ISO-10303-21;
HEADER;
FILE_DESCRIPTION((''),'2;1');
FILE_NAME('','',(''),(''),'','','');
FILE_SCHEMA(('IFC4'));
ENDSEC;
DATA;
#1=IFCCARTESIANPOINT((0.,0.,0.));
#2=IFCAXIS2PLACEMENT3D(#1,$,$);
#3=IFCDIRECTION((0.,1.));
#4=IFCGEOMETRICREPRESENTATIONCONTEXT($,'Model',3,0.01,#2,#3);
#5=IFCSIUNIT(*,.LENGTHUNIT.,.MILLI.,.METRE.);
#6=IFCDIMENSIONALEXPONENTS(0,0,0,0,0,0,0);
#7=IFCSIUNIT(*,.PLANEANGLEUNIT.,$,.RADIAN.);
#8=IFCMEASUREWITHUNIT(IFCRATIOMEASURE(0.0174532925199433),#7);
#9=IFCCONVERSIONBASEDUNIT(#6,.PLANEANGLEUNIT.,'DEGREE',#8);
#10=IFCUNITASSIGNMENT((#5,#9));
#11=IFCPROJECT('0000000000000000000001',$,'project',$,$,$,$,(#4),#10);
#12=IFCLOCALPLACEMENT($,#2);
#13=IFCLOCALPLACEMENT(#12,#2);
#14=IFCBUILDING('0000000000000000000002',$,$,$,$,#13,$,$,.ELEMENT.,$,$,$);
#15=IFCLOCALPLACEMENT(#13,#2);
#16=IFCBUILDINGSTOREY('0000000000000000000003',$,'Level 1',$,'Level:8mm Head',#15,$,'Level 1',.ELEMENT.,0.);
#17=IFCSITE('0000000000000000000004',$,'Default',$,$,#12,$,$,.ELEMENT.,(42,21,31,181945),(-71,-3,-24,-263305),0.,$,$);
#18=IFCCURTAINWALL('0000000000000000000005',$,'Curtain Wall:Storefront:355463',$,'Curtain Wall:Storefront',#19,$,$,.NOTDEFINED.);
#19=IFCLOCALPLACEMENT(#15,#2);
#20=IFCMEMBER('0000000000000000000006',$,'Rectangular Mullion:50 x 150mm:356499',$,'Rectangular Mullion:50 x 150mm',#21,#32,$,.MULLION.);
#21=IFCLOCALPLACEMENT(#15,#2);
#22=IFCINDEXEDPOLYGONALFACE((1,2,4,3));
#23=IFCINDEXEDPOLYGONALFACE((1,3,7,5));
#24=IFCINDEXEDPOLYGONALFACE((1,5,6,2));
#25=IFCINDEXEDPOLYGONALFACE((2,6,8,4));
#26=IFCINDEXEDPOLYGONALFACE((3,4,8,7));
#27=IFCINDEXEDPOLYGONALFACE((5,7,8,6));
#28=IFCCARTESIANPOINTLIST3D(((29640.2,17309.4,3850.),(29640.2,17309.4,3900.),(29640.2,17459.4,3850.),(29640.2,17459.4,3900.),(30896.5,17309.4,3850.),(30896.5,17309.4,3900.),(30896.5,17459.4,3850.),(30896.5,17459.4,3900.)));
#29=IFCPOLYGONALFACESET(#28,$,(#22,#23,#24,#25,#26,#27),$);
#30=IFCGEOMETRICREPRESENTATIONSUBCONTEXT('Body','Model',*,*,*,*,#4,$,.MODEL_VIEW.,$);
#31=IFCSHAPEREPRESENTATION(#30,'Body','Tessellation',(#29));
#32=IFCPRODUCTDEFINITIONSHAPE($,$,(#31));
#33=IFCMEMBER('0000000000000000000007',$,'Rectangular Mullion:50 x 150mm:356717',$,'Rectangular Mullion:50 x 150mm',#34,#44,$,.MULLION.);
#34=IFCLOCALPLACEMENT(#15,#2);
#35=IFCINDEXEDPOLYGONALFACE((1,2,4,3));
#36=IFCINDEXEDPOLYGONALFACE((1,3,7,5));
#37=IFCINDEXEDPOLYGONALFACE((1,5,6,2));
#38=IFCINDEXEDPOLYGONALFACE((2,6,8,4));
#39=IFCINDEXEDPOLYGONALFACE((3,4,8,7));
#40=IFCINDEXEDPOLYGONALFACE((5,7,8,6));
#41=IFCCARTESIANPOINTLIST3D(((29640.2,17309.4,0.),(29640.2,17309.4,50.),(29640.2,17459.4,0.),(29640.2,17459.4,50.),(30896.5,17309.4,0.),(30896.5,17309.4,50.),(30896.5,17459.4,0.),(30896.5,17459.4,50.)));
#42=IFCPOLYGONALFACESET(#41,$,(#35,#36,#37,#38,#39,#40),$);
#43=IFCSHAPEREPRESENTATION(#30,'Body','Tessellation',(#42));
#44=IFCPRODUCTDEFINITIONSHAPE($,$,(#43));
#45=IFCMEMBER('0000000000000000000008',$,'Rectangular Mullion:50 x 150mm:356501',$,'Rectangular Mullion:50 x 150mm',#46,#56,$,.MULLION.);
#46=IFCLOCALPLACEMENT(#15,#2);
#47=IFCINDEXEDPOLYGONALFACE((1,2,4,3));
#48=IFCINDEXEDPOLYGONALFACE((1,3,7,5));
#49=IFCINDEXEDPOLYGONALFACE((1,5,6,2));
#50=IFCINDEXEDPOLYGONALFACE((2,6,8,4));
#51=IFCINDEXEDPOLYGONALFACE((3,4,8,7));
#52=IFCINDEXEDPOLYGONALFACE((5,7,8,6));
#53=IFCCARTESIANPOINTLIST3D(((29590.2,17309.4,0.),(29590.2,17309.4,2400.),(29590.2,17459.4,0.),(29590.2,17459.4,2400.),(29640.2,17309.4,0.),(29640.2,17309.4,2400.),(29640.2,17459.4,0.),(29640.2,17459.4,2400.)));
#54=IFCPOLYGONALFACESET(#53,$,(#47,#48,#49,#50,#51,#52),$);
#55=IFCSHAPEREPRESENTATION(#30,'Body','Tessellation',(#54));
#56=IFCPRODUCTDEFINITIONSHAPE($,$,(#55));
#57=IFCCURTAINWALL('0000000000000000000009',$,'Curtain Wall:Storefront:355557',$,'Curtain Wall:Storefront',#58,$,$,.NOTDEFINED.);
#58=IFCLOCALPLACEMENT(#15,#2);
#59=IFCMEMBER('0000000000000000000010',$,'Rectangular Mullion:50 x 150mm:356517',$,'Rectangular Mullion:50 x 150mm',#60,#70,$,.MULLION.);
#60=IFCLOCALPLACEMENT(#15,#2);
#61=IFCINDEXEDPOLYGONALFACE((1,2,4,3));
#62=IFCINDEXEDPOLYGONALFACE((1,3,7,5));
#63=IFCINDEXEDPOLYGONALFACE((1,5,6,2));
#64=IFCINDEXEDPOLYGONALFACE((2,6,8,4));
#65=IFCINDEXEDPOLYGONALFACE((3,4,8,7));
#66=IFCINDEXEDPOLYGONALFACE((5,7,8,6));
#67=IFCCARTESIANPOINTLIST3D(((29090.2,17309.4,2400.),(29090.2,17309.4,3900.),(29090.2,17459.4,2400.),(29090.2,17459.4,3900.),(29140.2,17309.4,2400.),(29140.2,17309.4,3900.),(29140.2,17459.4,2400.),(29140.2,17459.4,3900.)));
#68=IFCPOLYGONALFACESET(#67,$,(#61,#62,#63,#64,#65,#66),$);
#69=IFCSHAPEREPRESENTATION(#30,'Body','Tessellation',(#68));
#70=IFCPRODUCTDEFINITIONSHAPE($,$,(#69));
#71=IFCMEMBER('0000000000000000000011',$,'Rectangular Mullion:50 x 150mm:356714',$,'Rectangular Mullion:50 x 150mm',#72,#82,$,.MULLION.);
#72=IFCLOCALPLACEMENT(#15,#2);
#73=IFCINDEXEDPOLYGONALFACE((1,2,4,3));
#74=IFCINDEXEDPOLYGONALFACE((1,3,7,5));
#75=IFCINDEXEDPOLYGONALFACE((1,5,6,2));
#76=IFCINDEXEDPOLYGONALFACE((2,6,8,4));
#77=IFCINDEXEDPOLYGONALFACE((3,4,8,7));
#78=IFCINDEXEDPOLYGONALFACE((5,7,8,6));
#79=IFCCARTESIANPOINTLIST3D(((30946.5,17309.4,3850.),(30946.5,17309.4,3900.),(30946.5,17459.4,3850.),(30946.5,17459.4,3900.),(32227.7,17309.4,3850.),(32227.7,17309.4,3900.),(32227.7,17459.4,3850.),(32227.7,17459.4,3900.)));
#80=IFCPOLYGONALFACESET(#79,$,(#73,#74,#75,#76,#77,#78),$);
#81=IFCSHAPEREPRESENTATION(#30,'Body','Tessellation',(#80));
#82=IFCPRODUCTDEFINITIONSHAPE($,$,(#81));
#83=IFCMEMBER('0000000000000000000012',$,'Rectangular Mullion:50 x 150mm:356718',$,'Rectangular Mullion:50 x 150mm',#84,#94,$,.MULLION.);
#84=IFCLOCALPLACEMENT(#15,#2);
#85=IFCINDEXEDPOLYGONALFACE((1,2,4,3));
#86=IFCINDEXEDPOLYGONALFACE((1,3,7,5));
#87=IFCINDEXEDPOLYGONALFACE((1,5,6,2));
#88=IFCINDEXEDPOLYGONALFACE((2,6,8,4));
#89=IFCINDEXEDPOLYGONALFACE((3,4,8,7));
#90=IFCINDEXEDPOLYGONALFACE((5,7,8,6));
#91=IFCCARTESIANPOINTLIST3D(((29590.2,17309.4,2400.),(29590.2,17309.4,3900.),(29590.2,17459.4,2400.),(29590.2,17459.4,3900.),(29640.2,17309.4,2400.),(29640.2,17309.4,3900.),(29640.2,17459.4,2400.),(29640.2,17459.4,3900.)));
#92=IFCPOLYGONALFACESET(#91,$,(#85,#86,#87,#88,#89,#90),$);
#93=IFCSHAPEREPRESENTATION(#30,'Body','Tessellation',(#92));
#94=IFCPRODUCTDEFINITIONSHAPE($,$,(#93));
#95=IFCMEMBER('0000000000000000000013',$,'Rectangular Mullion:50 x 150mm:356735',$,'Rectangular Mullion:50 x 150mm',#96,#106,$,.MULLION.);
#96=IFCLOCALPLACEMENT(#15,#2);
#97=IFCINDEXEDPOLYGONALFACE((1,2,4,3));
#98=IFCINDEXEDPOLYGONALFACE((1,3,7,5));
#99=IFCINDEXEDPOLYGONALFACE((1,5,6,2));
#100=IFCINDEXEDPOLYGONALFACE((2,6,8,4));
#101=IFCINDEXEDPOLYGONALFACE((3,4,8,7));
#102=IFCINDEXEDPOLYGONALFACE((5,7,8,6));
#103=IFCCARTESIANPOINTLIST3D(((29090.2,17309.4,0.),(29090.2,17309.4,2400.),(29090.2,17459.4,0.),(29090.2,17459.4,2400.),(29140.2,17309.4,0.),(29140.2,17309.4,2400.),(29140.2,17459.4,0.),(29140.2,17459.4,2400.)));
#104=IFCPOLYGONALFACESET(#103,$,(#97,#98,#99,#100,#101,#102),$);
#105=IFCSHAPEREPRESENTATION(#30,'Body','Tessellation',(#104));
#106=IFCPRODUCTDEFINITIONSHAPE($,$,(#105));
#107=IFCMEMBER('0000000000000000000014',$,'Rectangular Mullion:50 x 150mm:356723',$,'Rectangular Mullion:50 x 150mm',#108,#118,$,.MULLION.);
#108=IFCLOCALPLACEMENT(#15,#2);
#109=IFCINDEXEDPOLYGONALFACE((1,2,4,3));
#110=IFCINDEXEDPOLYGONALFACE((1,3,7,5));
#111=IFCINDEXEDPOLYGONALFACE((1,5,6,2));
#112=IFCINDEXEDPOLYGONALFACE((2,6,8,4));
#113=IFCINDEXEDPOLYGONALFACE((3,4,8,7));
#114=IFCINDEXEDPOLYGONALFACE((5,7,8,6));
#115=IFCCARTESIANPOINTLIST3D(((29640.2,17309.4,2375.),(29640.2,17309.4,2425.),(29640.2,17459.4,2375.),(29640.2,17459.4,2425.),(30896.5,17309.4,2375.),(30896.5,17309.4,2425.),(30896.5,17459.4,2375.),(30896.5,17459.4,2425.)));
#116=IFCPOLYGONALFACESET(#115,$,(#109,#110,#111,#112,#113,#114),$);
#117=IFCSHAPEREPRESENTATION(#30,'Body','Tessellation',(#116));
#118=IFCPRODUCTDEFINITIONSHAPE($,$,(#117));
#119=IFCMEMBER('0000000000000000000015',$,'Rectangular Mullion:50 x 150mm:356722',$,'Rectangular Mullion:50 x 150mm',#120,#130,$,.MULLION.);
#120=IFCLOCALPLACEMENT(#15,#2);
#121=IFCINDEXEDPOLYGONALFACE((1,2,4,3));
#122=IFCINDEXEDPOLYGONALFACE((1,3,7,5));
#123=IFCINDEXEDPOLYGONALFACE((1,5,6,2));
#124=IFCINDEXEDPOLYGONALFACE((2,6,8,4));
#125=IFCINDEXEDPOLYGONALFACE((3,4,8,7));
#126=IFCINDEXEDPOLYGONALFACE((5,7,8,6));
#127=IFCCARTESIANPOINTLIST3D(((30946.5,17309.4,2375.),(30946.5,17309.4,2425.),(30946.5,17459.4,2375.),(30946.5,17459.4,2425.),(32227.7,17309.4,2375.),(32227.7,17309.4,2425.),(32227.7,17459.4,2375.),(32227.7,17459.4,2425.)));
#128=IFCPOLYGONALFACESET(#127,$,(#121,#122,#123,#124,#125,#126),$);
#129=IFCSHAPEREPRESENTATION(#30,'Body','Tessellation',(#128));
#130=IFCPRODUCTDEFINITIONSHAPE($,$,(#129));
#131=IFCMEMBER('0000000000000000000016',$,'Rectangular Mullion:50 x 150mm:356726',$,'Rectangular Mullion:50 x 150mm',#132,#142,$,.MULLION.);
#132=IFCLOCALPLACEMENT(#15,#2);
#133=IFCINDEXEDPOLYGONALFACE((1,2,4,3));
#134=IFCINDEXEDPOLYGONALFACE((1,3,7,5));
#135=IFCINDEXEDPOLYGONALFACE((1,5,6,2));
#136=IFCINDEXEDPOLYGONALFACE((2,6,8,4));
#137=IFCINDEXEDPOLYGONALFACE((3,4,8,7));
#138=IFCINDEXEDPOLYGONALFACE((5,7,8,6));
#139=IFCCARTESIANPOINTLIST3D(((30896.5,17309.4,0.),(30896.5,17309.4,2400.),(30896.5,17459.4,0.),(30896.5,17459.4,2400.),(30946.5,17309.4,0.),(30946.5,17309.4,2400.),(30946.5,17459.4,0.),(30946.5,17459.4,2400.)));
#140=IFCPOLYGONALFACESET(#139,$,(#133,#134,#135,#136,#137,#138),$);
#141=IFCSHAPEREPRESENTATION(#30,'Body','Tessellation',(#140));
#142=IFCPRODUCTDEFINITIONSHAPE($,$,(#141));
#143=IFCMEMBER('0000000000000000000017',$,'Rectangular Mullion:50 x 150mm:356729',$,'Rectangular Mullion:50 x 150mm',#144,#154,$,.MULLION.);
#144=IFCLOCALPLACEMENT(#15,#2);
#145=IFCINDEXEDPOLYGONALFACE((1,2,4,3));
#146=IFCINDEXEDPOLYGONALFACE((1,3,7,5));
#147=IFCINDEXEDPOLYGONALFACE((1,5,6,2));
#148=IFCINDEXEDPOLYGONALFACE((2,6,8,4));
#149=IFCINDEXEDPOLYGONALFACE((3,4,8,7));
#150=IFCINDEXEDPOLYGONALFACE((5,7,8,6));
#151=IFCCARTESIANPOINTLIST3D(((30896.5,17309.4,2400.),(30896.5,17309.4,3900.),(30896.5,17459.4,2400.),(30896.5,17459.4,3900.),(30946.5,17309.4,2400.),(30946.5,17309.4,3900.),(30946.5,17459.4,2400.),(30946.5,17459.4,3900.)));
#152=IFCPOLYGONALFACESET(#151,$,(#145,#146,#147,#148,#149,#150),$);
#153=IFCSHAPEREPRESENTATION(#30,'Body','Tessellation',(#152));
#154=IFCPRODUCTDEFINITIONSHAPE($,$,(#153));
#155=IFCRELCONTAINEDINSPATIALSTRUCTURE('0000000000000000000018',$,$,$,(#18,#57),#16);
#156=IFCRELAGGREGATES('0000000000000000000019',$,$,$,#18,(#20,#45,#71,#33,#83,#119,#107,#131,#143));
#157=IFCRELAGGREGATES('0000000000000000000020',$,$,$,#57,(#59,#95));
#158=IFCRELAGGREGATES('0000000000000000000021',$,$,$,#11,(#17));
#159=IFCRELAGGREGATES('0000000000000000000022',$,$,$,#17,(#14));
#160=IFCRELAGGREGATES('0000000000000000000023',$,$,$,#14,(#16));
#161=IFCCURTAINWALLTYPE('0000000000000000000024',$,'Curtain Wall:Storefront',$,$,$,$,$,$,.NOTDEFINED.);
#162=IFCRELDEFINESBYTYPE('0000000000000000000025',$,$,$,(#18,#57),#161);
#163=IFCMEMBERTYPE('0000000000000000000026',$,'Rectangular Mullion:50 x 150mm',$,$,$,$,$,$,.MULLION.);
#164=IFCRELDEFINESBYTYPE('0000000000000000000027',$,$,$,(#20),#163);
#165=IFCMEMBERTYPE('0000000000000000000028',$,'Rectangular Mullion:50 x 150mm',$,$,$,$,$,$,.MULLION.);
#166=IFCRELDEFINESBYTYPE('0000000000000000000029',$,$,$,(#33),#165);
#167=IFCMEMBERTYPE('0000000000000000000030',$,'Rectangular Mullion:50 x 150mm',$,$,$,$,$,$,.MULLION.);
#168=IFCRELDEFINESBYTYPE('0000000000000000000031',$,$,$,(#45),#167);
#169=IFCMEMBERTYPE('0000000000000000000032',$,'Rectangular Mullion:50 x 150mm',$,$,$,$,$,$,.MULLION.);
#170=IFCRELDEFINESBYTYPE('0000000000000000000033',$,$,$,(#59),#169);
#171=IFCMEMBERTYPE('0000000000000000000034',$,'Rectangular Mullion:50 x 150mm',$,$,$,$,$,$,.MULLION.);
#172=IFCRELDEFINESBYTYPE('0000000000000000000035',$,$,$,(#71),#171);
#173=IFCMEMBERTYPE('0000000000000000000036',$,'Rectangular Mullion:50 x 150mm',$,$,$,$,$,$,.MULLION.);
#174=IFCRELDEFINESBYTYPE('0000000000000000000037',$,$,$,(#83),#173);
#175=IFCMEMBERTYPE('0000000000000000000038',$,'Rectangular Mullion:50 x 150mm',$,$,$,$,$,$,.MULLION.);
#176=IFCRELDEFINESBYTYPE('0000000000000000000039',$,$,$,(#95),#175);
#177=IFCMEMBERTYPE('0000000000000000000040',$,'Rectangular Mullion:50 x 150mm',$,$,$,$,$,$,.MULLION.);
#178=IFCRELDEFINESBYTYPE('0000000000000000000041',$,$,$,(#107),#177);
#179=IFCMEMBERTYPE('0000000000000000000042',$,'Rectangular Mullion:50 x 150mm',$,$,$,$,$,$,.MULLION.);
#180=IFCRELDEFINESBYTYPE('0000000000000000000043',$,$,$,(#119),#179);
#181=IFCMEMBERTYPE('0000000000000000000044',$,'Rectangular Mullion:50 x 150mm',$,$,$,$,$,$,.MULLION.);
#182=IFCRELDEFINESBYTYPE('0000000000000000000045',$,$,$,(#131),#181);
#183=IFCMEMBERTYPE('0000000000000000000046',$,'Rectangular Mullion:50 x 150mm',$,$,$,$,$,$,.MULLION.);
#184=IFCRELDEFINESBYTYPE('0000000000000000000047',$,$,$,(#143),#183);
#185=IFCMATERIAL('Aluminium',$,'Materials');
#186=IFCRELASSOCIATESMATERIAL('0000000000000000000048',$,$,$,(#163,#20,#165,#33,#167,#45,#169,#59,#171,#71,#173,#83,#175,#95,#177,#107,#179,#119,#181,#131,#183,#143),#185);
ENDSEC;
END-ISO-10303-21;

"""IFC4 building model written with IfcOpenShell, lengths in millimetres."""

from ifc_helpers import new_model, entity, si_unit, converted_unit, direction, frame, origin, place, context, subcontext, project, spatial, indexed_curve, outline, extrude, source, transform, mapped, material, type_object, type_shapes, element, aggregate, save


model = new_model("IFC4")

# Units and contexts
model_context = context("Model", 3, precision=0.01, world=origin(), true_north=direction((0.0, 1.0)))
body_context = subcontext(model_context, "Body", "Model", "MODEL_VIEW")
ifc_project = project(units=[si_unit("LENGTHUNIT", "METRE", prefix="MILLI"), converted_unit("PLANEANGLEUNIT", "DEGREE", entity("IfcRatioMeasure", 0.0174532925199433), si_unit("PLANEANGLEUNIT", "RADIAN"), dimensions=[0, 0, 0, 0, 0, 0, 0])], contexts=[model_context])

# Site, building, storey
site_placement = place(None, origin())
site = spatial("IfcSite", under=ifc_project, at=site_placement, Name="Default", CompositionType="ELEMENT", RefLatitude=(42, 21, 31, 181945), RefLongitude=(-71, -3, -24, -263305), RefElevation=0.0)
building_placement = place(site_placement, origin())
building = spatial("IfcBuilding", under=site, at=building_placement, CompositionType="ELEMENT")
storey_placement = place(building_placement, origin())
storey = spatial("IfcBuildingStorey", under=building, at=storey_placement, Name="Level 1", ObjectType="Level:8mm Head", LongName="Level 1", CompositionType="ELEMENT", Elevation=0.0)

# Curtain wall, members
curtain_wall_type_1 = type_object("IfcCurtainWallType", Name="Curtain Wall:Storefront", PredefinedType="NOTDEFINED")
curtain_wall_1_placement = place(storey_placement, origin())
curtain_wall_1 = element("IfcCurtainWall", 1, at=curtain_wall_1_placement, inside=storey, type_object=curtain_wall_type_1, Name="Curtain Wall:Storefront:355463", ObjectType="Curtain Wall:Storefront", PredefinedType="NOTDEFINED")
ifc_material_1 = material(Name="Aluminium", Category="Materials")
member_type_1 = type_object("IfcMemberType", Name="Rectangular Mullion:50 x 150mm", PredefinedType="MULLION", material=ifc_material_1)
shared_shape_1 = source(origin(), body_context, "Body", "SweptSolid", [
    extrude(outline(indexed_curve([(-75.0, -25.0), (75.0, -25.0), (75.0, 25.0), (-75.0, 25.0), (-75.0, -25.0)], self_intersect=False)), frame((-25.0, 0.0, -1256.3), z_axis=(0.0, 0.0, 1.0), x_axis=(0.0, -1.0, 0.0)), (0.0, 0.0, 1.0), 1256.3),
])
type_shapes(member_type_1, [shared_shape_1])
member_1_placement = place(storey_placement, frame((29640.2, 17384.4, 3900.0), z_axis=(-1.0, 0.0, 0.0), x_axis=(0.0, 0.0, 1.0)))
member_1 = element("IfcMember", 2, at=member_1_placement, type_object=member_type_1, material=ifc_material_1, Name="Rectangular Mullion:50 x 150mm:356499", ObjectType="Rectangular Mullion:50 x 150mm", PredefinedType="MULLION", context=body_context, shape_type="MappedRepresentation", body=[
    mapped(shared_shape_1, transform((0.0, 0.0, 0.0), scale=1.0)),
])
member_type_2 = type_object("IfcMemberType", Name="Rectangular Mullion:50 x 150mm", PredefinedType="MULLION", material=ifc_material_1)
shared_shape_2 = source(origin(), body_context, "Body", "SweptSolid", [
    extrude(outline(indexed_curve([(-75.0, -25.0), (75.0, -25.0), (75.0, 25.0), (-75.0, 25.0), (-75.0, -25.0)], self_intersect=False)), frame((-25.0, 0.0, -1256.3), z_axis=(0.0, 0.0, 1.0), x_axis=(0.0, -1.0, 0.0)), (0.0, 0.0, 1.0), 1256.3),
])
type_shapes(member_type_2, [shared_shape_2])
member_2_placement = place(storey_placement, frame((30896.5, 17384.4, 0.0), z_axis=(1.0, 0.0, 0.0), x_axis=(0.0, 0.0, -1.0)))
member_2 = element("IfcMember", 3, at=member_2_placement, type_object=member_type_2, material=ifc_material_1, Name="Rectangular Mullion:50 x 150mm:356717", ObjectType="Rectangular Mullion:50 x 150mm", PredefinedType="MULLION", context=body_context, shape_type="MappedRepresentation", body=[
    mapped(shared_shape_2, transform((0.0, 0.0, 0.0), scale=1.0)),
])
member_type_3 = type_object("IfcMemberType", Name="Rectangular Mullion:50 x 150mm", PredefinedType="MULLION", material=ifc_material_1)
shared_shape_3 = source(origin(), body_context, "Body", "SweptSolid", [
    extrude(outline(indexed_curve([(-75.0, -25.0), (75.0, -25.0), (75.0, 25.0), (-75.0, 25.0), (-75.0, -25.0)], self_intersect=False)), frame((-25.0, 0.0, -2400.0), z_axis=(0.0, 0.0, 1.0), x_axis=(0.0, -1.0, 0.0)), (0.0, 0.0, 1.0), 2400.0),
])
type_shapes(member_type_3, [shared_shape_3])
member_3_placement = place(storey_placement, frame((29590.2, 17384.4, 0.0), z_axis=(0.0, 0.0, -1.0), x_axis=(-1.0, 0.0, 0.0)))
member_3 = element("IfcMember", 4, at=member_3_placement, type_object=member_type_3, material=ifc_material_1, Name="Rectangular Mullion:50 x 150mm:356501", ObjectType="Rectangular Mullion:50 x 150mm", PredefinedType="MULLION", context=body_context, shape_type="MappedRepresentation", body=[
    mapped(shared_shape_3, transform((0.0, 0.0, 0.0), scale=1.0)),
])

# Curtain wall, member
curtain_wall_2_placement = place(storey_placement, origin())
curtain_wall_2 = element("IfcCurtainWall", 5, at=curtain_wall_2_placement, inside=storey, type_object=curtain_wall_type_1, Name="Curtain Wall:Storefront:355557", ObjectType="Curtain Wall:Storefront", PredefinedType="NOTDEFINED")
member_type_4 = type_object("IfcMemberType", Name="Rectangular Mullion:50 x 150mm", PredefinedType="MULLION", material=ifc_material_1)
shared_shape_4 = source(origin(), body_context, "Body", "SweptSolid", [
    extrude(outline(indexed_curve([(-75.0, -25.0), (75.0, -25.0), (75.0, 25.0), (-75.0, 25.0), (-75.0, -25.0)], self_intersect=False)), frame((-25.0, 0.0, -1500.0), z_axis=(0.0, 0.0, 1.0), x_axis=(0.0, -1.0, 0.0)), (0.0, 0.0, 1.0), 1500.0),
])
type_shapes(member_type_4, [shared_shape_4])
member_4_placement = place(storey_placement, frame((29140.2, 17384.4, 3900.0)))
member_4 = element("IfcMember", 6, at=member_4_placement, type_object=member_type_4, material=ifc_material_1, Name="Rectangular Mullion:50 x 150mm:356517", ObjectType="Rectangular Mullion:50 x 150mm", PredefinedType="MULLION", context=body_context, shape_type="MappedRepresentation", body=[
    mapped(shared_shape_4, transform((0.0, 0.0, 0.0), scale=1.0)),
])

# Members
member_type_5 = type_object("IfcMemberType", Name="Rectangular Mullion:50 x 150mm", PredefinedType="MULLION", material=ifc_material_1)
shared_shape_5 = source(origin(), body_context, "Body", "SweptSolid", [
    extrude(outline(indexed_curve([(-75.0, -25.0), (75.0, -25.0), (75.0, 25.0), (-75.0, 25.0), (-75.0, -25.0)], self_intersect=False)), frame((-25.0, 0.0, -1281.2), z_axis=(0.0, 0.0, 1.0), x_axis=(0.0, -1.0, 0.0)), (0.0, 0.0, 1.0), 1281.2),
])
type_shapes(member_type_5, [shared_shape_5])
member_5_placement = place(storey_placement, frame((30946.5, 17384.4, 3900.0), z_axis=(-1.0, 0.0, 0.0), x_axis=(0.0, 0.0, 1.0)))
member_5 = element("IfcMember", 7, at=member_5_placement, type_object=member_type_5, material=ifc_material_1, Name="Rectangular Mullion:50 x 150mm:356714", ObjectType="Rectangular Mullion:50 x 150mm", PredefinedType="MULLION", context=body_context, shape_type="MappedRepresentation", body=[
    mapped(shared_shape_5, transform((0.0, 0.0, 0.0), scale=1.0)),
])
member_type_6 = type_object("IfcMemberType", Name="Rectangular Mullion:50 x 150mm", PredefinedType="MULLION", material=ifc_material_1)
shared_shape_6 = source(origin(), body_context, "Body", "SweptSolid", [
    extrude(outline(indexed_curve([(-75.0, -25.0), (75.0, -25.0), (75.0, 25.0), (-75.0, 25.0), (-75.0, -25.0)], self_intersect=False)), frame((-25.0, 0.0, -1500.0), z_axis=(0.0, 0.0, 1.0), x_axis=(0.0, -1.0, 0.0)), (0.0, 0.0, 1.0), 1500.0),
])
type_shapes(member_type_6, [shared_shape_6])
member_6_placement = place(storey_placement, frame((29590.2, 17384.4, 2400.0), z_axis=(0.0, 0.0, -1.0), x_axis=(-1.0, 0.0, 0.0)))
member_6 = element("IfcMember", 8, at=member_6_placement, type_object=member_type_6, material=ifc_material_1, Name="Rectangular Mullion:50 x 150mm:356718", ObjectType="Rectangular Mullion:50 x 150mm", PredefinedType="MULLION", context=body_context, shape_type="MappedRepresentation", body=[
    mapped(shared_shape_6, transform((0.0, 0.0, 0.0), scale=1.0)),
])
member_type_7 = type_object("IfcMemberType", Name="Rectangular Mullion:50 x 150mm", PredefinedType="MULLION", material=ifc_material_1)
shared_shape_7 = source(origin(), body_context, "Body", "SweptSolid", [
    extrude(outline(indexed_curve([(-75.0, -25.0), (75.0, -25.0), (75.0, 25.0), (-75.0, 25.0), (-75.0, -25.0)], self_intersect=False)), frame((-25.0, 0.0, -2400.0), z_axis=(0.0, 0.0, 1.0), x_axis=(0.0, -1.0, 0.0)), (0.0, 0.0, 1.0), 2400.0),
])
type_shapes(member_type_7, [shared_shape_7])
member_7_placement = place(storey_placement, frame((29140.2, 17384.4, 2400.0)))
member_7 = element("IfcMember", 9, at=member_7_placement, type_object=member_type_7, material=ifc_material_1, Name="Rectangular Mullion:50 x 150mm:356735", ObjectType="Rectangular Mullion:50 x 150mm", PredefinedType="MULLION", context=body_context, shape_type="MappedRepresentation", body=[
    mapped(shared_shape_7, transform((0.0, 0.0, 0.0), scale=1.0)),
])
member_type_8 = type_object("IfcMemberType", Name="Rectangular Mullion:50 x 150mm", PredefinedType="MULLION", material=ifc_material_1)
shared_shape_8 = source(origin(), body_context, "Body", "SweptSolid", [
    extrude(outline(indexed_curve([(-75.0, -25.0), (75.0, -25.0), (75.0, 25.0), (-75.0, 25.0), (-75.0, -25.0)], self_intersect=False)), frame((0.0, 0.0, -1256.3), z_axis=(0.0, 0.0, 1.0), x_axis=(0.0, -1.0, 0.0)), (0.0, 0.0, 1.0), 1256.3),
])
type_shapes(member_type_8, [shared_shape_8])
member_8_placement = place(storey_placement, frame((29640.2, 17384.4, 2400.0), z_axis=(-1.0, 0.0, 0.0), x_axis=(0.0, 0.0, 1.0)))
member_8 = element("IfcMember", 10, at=member_8_placement, type_object=member_type_8, material=ifc_material_1, Name="Rectangular Mullion:50 x 150mm:356723", ObjectType="Rectangular Mullion:50 x 150mm", PredefinedType="MULLION", context=body_context, shape_type="MappedRepresentation", body=[
    mapped(shared_shape_8, transform((0.0, 0.0, 0.0), scale=1.0)),
])
member_type_9 = type_object("IfcMemberType", Name="Rectangular Mullion:50 x 150mm", PredefinedType="MULLION", material=ifc_material_1)
shared_shape_9 = source(origin(), body_context, "Body", "SweptSolid", [
    extrude(outline(indexed_curve([(-75.0, -25.0), (75.0, -25.0), (75.0, 25.0), (-75.0, 25.0), (-75.0, -25.0)], self_intersect=False)), frame((0.0, 0.0, -1281.2), z_axis=(0.0, 0.0, 1.0), x_axis=(0.0, -1.0, 0.0)), (0.0, 0.0, 1.0), 1281.2),
])
type_shapes(member_type_9, [shared_shape_9])
member_9_placement = place(storey_placement, frame((30946.5, 17384.4, 2400.0), z_axis=(-1.0, 0.0, 0.0), x_axis=(0.0, 0.0, 1.0)))
member_9 = element("IfcMember", 11, at=member_9_placement, type_object=member_type_9, material=ifc_material_1, Name="Rectangular Mullion:50 x 150mm:356722", ObjectType="Rectangular Mullion:50 x 150mm", PredefinedType="MULLION", context=body_context, shape_type="MappedRepresentation", body=[
    mapped(shared_shape_9, transform((0.0, 0.0, 0.0), scale=1.0)),
])
member_type_10 = type_object("IfcMemberType", Name="Rectangular Mullion:50 x 150mm", PredefinedType="MULLION", material=ifc_material_1)
shared_shape_10 = source(origin(), body_context, "Body", "SweptSolid", [
    extrude(outline(indexed_curve([(-75.0, -25.0), (75.0, -25.0), (75.0, 25.0), (-75.0, 25.0), (-75.0, -25.0)], self_intersect=False)), frame((0.0, 0.0, -2400.0), z_axis=(0.0, 0.0, 1.0), x_axis=(0.0, -1.0, 0.0)), (0.0, 0.0, 1.0), 2400.0),
])
type_shapes(member_type_10, [shared_shape_10])
member_10_placement = place(storey_placement, frame((30921.5, 17384.4, 0.0), z_axis=(0.0, 0.0, -1.0), x_axis=(-1.0, 0.0, 0.0)))
member_10 = element("IfcMember", 12, at=member_10_placement, type_object=member_type_10, material=ifc_material_1, Name="Rectangular Mullion:50 x 150mm:356726", ObjectType="Rectangular Mullion:50 x 150mm", PredefinedType="MULLION", context=body_context, shape_type="MappedRepresentation", body=[
    mapped(shared_shape_10, transform((0.0, 0.0, 0.0), scale=1.0)),
])
member_type_11 = type_object("IfcMemberType", Name="Rectangular Mullion:50 x 150mm", PredefinedType="MULLION", material=ifc_material_1)
shared_shape_11 = source(origin(), body_context, "Body", "SweptSolid", [
    extrude(outline(indexed_curve([(-75.0, -25.0), (75.0, -25.0), (75.0, 25.0), (-75.0, 25.0), (-75.0, -25.0)], self_intersect=False)), frame((0.0, 0.0, -1500.0), z_axis=(0.0, 0.0, 1.0), x_axis=(0.0, -1.0, 0.0)), (0.0, 0.0, 1.0), 1500.0),
])
type_shapes(member_type_11, [shared_shape_11])
member_11_placement = place(storey_placement, frame((30921.5, 17384.4, 2400.0), z_axis=(0.0, 0.0, -1.0), x_axis=(-1.0, 0.0, 0.0)))
member_11 = element("IfcMember", 13, at=member_11_placement, type_object=member_type_11, material=ifc_material_1, Name="Rectangular Mullion:50 x 150mm:356729", ObjectType="Rectangular Mullion:50 x 150mm", PredefinedType="MULLION", context=body_context, shape_type="MappedRepresentation", body=[
    mapped(shared_shape_11, transform((0.0, 0.0, 0.0), scale=1.0)),
])

aggregate(curtain_wall_1, [member_1, member_3, member_5, member_2, member_6, member_9, member_8, member_10, member_11])
aggregate(curtain_wall_2, [member_4, member_7])

save(model, "model.ifc")
